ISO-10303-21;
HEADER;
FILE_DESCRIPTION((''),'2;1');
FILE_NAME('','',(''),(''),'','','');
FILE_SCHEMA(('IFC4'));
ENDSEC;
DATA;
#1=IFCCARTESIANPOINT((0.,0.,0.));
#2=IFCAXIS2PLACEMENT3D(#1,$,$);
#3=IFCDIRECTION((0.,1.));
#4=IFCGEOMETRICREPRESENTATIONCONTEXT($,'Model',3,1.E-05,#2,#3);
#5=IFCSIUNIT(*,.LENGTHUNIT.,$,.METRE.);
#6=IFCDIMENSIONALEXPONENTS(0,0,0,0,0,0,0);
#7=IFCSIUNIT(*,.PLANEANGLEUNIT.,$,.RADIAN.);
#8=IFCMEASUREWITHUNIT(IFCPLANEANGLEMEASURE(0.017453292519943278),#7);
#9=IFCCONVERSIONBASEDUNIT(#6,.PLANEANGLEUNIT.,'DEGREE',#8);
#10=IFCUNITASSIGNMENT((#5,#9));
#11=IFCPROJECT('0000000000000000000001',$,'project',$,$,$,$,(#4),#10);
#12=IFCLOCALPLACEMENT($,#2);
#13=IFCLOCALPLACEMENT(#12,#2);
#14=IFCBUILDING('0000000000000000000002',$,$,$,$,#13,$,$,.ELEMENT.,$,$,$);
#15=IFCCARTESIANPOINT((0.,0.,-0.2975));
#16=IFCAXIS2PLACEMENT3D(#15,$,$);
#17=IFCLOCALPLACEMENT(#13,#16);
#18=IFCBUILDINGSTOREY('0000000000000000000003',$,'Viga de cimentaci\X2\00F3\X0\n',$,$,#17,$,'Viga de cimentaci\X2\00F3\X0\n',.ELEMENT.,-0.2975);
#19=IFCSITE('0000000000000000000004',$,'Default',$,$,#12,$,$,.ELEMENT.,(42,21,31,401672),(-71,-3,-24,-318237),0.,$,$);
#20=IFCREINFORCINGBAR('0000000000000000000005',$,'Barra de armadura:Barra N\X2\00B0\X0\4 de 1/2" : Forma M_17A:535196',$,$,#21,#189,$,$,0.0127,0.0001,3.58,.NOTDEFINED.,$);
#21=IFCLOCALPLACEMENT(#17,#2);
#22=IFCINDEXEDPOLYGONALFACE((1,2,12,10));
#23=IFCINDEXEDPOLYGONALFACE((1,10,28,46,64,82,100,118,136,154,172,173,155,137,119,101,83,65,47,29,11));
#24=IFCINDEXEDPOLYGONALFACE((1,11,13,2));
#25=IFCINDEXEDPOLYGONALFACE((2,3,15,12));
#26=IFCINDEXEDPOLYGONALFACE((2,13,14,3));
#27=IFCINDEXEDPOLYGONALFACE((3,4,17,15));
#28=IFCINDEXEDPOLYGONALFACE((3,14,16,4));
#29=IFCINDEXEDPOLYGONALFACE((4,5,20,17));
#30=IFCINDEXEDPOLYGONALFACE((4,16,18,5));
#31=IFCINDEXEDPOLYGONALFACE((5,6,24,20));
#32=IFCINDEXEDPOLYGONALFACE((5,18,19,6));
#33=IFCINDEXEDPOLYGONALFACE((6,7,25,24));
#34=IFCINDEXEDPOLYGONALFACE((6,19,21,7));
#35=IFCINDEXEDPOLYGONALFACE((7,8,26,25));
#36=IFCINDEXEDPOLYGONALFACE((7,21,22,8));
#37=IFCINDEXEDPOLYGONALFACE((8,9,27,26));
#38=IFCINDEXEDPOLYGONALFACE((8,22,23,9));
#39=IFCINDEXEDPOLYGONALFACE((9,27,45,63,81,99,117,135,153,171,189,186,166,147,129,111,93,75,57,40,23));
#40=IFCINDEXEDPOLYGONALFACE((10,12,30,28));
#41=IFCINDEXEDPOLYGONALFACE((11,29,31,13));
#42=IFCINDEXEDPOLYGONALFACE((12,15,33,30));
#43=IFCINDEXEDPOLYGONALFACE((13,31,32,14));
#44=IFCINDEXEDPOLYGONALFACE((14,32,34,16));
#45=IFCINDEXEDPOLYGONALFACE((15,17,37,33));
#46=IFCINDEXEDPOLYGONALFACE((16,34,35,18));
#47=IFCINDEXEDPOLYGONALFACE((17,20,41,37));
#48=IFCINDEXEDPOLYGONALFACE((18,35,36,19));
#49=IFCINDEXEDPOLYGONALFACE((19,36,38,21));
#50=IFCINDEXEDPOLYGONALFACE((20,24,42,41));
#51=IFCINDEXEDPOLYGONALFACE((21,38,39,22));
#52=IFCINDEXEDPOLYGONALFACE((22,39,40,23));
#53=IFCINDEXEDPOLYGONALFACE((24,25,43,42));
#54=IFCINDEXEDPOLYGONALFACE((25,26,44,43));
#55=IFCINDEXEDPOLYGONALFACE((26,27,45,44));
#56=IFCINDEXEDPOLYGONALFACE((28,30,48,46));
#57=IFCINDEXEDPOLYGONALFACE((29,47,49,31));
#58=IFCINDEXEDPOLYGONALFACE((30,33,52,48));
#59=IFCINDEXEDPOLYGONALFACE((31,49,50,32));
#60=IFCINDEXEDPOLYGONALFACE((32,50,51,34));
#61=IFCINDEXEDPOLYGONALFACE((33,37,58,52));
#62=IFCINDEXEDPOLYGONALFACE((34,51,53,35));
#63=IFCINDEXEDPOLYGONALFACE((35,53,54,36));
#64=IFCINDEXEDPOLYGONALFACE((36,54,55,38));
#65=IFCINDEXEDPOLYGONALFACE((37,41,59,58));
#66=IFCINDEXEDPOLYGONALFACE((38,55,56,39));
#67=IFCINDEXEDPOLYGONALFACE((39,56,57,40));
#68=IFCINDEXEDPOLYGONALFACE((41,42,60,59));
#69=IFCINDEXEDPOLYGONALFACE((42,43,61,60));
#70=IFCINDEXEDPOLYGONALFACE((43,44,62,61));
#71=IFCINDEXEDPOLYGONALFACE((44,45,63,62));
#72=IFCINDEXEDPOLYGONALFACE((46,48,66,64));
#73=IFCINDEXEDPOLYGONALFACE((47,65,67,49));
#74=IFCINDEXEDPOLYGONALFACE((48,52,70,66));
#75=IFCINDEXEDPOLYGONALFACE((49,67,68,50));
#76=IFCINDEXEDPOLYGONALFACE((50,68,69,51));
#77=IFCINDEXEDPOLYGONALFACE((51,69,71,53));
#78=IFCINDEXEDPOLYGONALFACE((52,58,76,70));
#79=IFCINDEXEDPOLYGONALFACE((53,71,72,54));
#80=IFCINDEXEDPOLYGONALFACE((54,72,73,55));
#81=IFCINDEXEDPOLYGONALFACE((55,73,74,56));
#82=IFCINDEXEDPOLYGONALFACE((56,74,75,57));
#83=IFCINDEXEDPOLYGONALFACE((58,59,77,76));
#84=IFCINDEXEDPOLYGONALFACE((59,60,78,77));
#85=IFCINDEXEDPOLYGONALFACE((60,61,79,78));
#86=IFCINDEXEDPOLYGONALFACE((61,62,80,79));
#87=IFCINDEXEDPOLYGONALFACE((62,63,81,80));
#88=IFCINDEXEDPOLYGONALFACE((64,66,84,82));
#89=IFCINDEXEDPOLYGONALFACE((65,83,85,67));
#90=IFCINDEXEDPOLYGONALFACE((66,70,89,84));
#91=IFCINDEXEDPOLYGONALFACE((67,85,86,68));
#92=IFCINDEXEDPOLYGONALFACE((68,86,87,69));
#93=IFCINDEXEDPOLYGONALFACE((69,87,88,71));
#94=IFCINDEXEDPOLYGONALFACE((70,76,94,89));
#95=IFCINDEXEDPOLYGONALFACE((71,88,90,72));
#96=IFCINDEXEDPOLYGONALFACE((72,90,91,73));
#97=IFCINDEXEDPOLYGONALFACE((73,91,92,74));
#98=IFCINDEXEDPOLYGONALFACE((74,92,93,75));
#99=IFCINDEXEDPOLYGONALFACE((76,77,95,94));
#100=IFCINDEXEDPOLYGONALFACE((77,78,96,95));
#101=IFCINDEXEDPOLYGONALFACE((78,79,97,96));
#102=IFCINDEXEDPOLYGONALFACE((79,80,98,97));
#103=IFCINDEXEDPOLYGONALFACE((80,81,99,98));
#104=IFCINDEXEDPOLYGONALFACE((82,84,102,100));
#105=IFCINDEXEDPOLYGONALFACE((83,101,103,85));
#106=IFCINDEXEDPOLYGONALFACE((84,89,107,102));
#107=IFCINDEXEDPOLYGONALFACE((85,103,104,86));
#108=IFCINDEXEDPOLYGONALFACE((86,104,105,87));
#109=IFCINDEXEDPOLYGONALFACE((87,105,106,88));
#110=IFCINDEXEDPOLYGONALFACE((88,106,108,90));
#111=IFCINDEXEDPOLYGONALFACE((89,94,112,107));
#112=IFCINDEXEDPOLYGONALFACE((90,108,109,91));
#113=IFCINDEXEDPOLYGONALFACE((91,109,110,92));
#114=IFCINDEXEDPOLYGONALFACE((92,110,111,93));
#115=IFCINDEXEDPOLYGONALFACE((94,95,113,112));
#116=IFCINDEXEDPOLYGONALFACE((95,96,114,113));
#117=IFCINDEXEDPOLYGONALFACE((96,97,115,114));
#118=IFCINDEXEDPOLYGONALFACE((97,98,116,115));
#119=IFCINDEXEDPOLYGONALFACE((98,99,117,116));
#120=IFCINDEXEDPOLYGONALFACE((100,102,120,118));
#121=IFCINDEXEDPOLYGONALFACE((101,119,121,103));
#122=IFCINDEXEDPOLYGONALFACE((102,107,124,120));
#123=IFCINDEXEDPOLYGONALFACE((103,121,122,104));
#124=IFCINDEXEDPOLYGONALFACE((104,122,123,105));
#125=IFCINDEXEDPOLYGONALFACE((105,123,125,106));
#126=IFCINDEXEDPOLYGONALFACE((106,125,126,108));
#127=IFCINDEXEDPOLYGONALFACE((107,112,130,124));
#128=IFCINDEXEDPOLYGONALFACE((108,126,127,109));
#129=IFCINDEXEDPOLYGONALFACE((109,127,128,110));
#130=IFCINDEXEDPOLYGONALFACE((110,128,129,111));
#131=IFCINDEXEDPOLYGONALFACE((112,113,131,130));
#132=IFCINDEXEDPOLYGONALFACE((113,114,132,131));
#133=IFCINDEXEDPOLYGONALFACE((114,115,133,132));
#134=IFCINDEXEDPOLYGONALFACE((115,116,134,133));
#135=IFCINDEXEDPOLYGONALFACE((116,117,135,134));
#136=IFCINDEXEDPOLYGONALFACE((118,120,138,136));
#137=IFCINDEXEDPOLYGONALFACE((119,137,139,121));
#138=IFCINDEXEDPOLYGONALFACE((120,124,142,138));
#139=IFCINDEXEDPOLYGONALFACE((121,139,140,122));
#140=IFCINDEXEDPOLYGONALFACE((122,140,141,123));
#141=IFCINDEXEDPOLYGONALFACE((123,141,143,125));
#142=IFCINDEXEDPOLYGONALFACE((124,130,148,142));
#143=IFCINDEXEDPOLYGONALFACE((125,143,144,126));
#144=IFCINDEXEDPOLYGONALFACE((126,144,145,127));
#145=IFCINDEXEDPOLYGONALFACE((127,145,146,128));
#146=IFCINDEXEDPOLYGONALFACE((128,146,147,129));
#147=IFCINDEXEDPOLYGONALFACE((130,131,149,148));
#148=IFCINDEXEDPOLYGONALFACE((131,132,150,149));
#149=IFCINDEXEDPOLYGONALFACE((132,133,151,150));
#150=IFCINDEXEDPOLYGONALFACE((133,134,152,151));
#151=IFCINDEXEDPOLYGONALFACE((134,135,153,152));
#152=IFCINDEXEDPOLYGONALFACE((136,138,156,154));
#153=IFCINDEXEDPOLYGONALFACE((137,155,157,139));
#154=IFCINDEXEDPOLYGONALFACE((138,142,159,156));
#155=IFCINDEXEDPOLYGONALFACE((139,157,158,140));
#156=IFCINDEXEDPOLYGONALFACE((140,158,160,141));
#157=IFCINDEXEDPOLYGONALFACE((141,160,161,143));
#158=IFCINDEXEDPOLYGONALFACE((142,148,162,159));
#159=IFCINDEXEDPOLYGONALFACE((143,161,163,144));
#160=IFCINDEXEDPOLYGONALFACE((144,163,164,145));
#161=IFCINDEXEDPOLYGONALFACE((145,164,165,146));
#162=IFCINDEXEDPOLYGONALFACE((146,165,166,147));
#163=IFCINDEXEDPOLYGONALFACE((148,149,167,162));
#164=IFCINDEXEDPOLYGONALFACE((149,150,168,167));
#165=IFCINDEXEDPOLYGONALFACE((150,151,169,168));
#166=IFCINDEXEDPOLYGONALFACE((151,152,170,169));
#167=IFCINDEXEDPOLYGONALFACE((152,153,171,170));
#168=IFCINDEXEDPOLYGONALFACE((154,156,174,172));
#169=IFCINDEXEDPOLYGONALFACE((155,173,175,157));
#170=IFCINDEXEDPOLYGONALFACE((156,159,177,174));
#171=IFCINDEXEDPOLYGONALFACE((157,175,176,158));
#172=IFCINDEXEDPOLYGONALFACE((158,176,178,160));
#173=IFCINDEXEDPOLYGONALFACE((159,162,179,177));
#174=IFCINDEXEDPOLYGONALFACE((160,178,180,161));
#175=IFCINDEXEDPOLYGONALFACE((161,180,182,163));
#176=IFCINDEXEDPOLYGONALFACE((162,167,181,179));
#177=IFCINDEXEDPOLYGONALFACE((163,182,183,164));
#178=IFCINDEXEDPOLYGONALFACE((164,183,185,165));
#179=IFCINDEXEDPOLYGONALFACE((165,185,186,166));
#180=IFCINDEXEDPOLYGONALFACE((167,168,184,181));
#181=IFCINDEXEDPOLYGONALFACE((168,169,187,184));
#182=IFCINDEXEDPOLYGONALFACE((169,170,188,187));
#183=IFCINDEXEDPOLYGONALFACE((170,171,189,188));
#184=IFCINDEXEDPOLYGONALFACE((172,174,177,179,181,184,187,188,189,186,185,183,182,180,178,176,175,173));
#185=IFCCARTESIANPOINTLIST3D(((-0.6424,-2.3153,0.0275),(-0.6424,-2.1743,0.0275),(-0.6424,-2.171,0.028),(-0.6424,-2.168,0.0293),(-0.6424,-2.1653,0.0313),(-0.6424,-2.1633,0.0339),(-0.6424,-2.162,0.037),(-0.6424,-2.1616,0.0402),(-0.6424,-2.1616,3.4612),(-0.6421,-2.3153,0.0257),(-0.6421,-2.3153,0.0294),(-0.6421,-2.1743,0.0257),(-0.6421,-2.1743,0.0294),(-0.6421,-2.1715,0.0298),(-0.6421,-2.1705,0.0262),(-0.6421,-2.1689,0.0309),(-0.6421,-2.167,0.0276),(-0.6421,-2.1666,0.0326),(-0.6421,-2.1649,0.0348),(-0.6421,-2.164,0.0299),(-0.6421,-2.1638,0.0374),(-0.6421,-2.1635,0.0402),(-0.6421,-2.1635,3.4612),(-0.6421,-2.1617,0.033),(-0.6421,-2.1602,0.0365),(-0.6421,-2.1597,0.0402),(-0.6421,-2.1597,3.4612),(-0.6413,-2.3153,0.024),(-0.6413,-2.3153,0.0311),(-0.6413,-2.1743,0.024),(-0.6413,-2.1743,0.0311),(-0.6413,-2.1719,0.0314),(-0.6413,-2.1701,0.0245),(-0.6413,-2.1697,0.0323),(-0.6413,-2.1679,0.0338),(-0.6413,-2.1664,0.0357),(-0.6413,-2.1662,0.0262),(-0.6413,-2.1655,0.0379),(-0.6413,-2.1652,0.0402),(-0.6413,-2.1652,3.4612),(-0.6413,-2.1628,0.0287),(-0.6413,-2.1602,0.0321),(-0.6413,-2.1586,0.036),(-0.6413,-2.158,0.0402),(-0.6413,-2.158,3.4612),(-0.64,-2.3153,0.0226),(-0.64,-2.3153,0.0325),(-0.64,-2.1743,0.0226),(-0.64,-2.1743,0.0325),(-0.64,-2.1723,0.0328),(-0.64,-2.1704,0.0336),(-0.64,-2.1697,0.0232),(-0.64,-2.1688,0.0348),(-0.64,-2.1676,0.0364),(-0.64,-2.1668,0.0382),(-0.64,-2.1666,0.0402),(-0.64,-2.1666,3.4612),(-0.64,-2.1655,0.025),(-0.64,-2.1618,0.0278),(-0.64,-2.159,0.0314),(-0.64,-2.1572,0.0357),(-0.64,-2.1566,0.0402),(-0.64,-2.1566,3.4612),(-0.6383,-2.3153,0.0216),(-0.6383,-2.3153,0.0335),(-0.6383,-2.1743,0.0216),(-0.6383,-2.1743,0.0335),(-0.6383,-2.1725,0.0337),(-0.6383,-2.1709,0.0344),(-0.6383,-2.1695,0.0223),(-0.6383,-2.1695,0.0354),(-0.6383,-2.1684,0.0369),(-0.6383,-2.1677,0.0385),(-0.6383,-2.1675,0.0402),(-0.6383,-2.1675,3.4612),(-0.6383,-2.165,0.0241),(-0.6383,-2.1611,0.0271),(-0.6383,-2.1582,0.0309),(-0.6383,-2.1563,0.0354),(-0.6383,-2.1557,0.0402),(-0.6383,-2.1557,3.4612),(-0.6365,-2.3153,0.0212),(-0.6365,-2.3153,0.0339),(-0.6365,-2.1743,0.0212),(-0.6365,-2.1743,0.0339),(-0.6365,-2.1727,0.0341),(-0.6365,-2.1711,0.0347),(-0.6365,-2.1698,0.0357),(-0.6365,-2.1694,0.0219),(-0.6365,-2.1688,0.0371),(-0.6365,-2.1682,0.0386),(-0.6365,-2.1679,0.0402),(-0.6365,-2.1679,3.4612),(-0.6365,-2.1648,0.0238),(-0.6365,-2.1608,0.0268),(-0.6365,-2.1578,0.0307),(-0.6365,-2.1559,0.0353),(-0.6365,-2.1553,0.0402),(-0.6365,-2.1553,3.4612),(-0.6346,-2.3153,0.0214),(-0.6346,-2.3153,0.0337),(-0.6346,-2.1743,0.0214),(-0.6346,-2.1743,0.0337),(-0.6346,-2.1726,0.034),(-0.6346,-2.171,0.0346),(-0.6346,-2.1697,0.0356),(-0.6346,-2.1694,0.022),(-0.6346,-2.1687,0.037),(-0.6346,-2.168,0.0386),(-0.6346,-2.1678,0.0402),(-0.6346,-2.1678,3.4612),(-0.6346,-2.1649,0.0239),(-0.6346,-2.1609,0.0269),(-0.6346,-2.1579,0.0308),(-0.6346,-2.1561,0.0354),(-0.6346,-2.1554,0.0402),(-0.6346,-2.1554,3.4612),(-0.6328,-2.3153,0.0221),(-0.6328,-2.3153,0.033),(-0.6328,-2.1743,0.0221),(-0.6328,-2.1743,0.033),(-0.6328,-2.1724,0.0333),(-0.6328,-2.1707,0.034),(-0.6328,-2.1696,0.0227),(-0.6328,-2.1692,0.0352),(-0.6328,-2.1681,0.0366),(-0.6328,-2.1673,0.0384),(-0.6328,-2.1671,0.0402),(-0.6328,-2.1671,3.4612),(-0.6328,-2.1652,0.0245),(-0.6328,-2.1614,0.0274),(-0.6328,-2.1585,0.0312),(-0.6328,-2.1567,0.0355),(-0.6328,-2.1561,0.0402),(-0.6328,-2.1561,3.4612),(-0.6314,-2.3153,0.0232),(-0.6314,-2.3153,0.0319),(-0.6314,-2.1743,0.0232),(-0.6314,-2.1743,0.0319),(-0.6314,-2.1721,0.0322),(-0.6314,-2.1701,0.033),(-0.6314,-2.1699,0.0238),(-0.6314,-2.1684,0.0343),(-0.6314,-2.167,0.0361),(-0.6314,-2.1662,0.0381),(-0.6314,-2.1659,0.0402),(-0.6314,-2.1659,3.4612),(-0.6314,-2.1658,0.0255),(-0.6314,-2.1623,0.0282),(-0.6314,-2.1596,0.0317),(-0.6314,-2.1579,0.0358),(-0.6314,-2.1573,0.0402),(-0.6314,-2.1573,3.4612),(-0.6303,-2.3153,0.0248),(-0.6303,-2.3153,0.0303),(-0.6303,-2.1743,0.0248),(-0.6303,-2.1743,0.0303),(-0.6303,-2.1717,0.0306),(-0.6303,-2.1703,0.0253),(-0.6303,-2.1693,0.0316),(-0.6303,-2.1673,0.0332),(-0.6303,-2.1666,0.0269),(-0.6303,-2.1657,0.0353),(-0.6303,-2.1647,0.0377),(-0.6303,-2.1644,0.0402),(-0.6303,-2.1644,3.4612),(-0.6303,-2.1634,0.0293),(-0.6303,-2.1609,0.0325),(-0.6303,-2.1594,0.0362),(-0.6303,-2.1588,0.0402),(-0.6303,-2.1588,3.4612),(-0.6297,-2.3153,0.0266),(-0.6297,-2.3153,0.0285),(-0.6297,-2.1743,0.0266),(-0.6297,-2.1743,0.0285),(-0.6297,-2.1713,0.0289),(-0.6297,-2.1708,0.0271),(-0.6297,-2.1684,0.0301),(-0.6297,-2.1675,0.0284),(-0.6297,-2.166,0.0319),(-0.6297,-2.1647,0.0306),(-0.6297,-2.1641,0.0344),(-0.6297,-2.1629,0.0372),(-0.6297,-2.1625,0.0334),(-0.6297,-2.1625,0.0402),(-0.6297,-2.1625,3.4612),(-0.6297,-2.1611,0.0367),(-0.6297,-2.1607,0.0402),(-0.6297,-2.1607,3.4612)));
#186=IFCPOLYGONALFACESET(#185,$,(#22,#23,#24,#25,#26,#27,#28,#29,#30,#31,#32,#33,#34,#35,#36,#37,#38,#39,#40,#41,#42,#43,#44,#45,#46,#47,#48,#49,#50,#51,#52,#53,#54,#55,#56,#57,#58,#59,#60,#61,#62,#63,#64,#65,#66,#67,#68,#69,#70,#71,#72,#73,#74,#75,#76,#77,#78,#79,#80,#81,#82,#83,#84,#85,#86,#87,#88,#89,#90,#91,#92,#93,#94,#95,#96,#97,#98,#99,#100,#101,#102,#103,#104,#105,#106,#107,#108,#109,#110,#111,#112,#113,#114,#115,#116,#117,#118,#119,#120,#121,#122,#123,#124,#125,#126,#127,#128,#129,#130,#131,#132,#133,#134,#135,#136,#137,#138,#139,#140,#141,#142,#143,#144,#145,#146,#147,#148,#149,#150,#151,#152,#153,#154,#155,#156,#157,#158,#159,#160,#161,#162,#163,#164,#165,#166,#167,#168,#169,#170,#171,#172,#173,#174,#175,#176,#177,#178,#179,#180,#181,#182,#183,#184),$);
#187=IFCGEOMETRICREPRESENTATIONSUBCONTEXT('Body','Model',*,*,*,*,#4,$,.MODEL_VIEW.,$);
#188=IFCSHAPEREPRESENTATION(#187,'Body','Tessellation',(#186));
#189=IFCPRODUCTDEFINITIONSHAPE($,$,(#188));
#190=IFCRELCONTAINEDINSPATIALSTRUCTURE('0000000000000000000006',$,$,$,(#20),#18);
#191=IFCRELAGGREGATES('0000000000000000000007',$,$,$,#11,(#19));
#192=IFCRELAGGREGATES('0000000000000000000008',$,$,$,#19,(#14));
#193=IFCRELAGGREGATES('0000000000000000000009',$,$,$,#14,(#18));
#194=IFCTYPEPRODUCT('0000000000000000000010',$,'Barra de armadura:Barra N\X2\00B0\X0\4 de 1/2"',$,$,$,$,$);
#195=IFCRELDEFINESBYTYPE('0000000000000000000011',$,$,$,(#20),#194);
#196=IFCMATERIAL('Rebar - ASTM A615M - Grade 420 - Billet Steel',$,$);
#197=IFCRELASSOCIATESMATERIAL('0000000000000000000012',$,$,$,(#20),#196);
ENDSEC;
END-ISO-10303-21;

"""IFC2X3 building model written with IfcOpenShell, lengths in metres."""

from ifc_helpers import new_model, entity, si_unit, converted_unit, direction, frame, origin, place, context, subcontext, project, spatial, material, type_object, element, save


model = new_model("IFC2X3")

# Units and contexts
model_context = context("Model", 3, precision=1e-05, world=origin(), true_north=direction((0.0, 1.0)))
body_context = subcontext(model_context, "Body", "Model", "MODEL_VIEW")
ifc_project = project(units=[si_unit("LENGTHUNIT", "METRE"), converted_unit("PLANEANGLEUNIT", "DEGREE", entity("IfcPlaneAngleMeasure", 0.017453292519943278), si_unit("PLANEANGLEUNIT", "RADIAN"), dimensions=[0, 0, 0, 0, 0, 0, 0])], contexts=[model_context])

# Site, building, storey
site_placement = place(None, origin())
site = spatial("IfcSite", under=ifc_project, at=site_placement, Name="Default", CompositionType="ELEMENT", RefLatitude=(42, 21, 31, 401672), RefLongitude=(-71, -3, -24, -318237), RefElevation=0.0)
building_placement = place(site_placement, origin())
building = spatial("IfcBuilding", under=site, at=building_placement, CompositionType="ELEMENT")
storey_placement = place(building_placement, frame((0.0, 0.0, -0.2975)))
storey = spatial("IfcBuildingStorey", under=building, at=storey_placement, Name="Viga de cimentación", LongName="Viga de cimentación", CompositionType="ELEMENT", Elevation=-0.2975)

# Reinforcing bar
ifc_material = material(Name="Rebar - ASTM A615M - Grade 420 - Billet Steel")
type_product_1 = type_object("IfcTypeProduct", Name="Barra de armadura:Barra N°4 de 1/2\"")
reinforcing_bar_1_placement = place(storey_placement, origin())
element("IfcReinforcingBar", 1, at=reinforcing_bar_1_placement, inside=storey, type_object=type_product_1, material=ifc_material, Name="Barra de armadura:Barra N°4 de 1/2\" : Forma M_17A:535196", BarLength=3.58, BarRole="NOTDEFINED", CrossSectionArea=0.0001, NominalDiameter=0.0127, context=body_context, shape_type="AdvancedSweptSolid", body=[
    entity("IfcSweptDiskSolid", entity("IfcCompositeCurve", [entity("IfcCompositeCurveSegment", "CONTINUOUS", True, entity("IfcPolyline", [entity("IfcCartesianPoint", [-0.636, -2.1616, 3.4612]), entity("IfcCartesianPoint", [-0.636, -2.1616, 0.0402])])), entity("IfcCompositeCurveSegment", "CONTINUOUS", True, entity("IfcTrimmedCurve", entity("IfcCircle", entity("IfcAxis2Placement3D", entity("IfcCartesianPoint", [-0.636, -2.1743, 0.0402]), entity("IfcDirection", [-1.0, 0.0, 0.0]), entity("IfcDirection", [0.0, 0.0, -1.0])), 0.0127), [entity("IfcParameterValue", 270.0)], [entity("IfcParameterValue", 360.0)], True, "PARAMETER")), entity("IfcCompositeCurveSegment", "CONTINUOUS", True, entity("IfcPolyline", [entity("IfcCartesianPoint", [-0.636, -2.1743, 0.0275]), entity("IfcCartesianPoint", [-0.636, -2.3153, 0.0275])]))], False), 0.0063, None, 0.0, 92.0),
])

save(model, "model.ifc")
